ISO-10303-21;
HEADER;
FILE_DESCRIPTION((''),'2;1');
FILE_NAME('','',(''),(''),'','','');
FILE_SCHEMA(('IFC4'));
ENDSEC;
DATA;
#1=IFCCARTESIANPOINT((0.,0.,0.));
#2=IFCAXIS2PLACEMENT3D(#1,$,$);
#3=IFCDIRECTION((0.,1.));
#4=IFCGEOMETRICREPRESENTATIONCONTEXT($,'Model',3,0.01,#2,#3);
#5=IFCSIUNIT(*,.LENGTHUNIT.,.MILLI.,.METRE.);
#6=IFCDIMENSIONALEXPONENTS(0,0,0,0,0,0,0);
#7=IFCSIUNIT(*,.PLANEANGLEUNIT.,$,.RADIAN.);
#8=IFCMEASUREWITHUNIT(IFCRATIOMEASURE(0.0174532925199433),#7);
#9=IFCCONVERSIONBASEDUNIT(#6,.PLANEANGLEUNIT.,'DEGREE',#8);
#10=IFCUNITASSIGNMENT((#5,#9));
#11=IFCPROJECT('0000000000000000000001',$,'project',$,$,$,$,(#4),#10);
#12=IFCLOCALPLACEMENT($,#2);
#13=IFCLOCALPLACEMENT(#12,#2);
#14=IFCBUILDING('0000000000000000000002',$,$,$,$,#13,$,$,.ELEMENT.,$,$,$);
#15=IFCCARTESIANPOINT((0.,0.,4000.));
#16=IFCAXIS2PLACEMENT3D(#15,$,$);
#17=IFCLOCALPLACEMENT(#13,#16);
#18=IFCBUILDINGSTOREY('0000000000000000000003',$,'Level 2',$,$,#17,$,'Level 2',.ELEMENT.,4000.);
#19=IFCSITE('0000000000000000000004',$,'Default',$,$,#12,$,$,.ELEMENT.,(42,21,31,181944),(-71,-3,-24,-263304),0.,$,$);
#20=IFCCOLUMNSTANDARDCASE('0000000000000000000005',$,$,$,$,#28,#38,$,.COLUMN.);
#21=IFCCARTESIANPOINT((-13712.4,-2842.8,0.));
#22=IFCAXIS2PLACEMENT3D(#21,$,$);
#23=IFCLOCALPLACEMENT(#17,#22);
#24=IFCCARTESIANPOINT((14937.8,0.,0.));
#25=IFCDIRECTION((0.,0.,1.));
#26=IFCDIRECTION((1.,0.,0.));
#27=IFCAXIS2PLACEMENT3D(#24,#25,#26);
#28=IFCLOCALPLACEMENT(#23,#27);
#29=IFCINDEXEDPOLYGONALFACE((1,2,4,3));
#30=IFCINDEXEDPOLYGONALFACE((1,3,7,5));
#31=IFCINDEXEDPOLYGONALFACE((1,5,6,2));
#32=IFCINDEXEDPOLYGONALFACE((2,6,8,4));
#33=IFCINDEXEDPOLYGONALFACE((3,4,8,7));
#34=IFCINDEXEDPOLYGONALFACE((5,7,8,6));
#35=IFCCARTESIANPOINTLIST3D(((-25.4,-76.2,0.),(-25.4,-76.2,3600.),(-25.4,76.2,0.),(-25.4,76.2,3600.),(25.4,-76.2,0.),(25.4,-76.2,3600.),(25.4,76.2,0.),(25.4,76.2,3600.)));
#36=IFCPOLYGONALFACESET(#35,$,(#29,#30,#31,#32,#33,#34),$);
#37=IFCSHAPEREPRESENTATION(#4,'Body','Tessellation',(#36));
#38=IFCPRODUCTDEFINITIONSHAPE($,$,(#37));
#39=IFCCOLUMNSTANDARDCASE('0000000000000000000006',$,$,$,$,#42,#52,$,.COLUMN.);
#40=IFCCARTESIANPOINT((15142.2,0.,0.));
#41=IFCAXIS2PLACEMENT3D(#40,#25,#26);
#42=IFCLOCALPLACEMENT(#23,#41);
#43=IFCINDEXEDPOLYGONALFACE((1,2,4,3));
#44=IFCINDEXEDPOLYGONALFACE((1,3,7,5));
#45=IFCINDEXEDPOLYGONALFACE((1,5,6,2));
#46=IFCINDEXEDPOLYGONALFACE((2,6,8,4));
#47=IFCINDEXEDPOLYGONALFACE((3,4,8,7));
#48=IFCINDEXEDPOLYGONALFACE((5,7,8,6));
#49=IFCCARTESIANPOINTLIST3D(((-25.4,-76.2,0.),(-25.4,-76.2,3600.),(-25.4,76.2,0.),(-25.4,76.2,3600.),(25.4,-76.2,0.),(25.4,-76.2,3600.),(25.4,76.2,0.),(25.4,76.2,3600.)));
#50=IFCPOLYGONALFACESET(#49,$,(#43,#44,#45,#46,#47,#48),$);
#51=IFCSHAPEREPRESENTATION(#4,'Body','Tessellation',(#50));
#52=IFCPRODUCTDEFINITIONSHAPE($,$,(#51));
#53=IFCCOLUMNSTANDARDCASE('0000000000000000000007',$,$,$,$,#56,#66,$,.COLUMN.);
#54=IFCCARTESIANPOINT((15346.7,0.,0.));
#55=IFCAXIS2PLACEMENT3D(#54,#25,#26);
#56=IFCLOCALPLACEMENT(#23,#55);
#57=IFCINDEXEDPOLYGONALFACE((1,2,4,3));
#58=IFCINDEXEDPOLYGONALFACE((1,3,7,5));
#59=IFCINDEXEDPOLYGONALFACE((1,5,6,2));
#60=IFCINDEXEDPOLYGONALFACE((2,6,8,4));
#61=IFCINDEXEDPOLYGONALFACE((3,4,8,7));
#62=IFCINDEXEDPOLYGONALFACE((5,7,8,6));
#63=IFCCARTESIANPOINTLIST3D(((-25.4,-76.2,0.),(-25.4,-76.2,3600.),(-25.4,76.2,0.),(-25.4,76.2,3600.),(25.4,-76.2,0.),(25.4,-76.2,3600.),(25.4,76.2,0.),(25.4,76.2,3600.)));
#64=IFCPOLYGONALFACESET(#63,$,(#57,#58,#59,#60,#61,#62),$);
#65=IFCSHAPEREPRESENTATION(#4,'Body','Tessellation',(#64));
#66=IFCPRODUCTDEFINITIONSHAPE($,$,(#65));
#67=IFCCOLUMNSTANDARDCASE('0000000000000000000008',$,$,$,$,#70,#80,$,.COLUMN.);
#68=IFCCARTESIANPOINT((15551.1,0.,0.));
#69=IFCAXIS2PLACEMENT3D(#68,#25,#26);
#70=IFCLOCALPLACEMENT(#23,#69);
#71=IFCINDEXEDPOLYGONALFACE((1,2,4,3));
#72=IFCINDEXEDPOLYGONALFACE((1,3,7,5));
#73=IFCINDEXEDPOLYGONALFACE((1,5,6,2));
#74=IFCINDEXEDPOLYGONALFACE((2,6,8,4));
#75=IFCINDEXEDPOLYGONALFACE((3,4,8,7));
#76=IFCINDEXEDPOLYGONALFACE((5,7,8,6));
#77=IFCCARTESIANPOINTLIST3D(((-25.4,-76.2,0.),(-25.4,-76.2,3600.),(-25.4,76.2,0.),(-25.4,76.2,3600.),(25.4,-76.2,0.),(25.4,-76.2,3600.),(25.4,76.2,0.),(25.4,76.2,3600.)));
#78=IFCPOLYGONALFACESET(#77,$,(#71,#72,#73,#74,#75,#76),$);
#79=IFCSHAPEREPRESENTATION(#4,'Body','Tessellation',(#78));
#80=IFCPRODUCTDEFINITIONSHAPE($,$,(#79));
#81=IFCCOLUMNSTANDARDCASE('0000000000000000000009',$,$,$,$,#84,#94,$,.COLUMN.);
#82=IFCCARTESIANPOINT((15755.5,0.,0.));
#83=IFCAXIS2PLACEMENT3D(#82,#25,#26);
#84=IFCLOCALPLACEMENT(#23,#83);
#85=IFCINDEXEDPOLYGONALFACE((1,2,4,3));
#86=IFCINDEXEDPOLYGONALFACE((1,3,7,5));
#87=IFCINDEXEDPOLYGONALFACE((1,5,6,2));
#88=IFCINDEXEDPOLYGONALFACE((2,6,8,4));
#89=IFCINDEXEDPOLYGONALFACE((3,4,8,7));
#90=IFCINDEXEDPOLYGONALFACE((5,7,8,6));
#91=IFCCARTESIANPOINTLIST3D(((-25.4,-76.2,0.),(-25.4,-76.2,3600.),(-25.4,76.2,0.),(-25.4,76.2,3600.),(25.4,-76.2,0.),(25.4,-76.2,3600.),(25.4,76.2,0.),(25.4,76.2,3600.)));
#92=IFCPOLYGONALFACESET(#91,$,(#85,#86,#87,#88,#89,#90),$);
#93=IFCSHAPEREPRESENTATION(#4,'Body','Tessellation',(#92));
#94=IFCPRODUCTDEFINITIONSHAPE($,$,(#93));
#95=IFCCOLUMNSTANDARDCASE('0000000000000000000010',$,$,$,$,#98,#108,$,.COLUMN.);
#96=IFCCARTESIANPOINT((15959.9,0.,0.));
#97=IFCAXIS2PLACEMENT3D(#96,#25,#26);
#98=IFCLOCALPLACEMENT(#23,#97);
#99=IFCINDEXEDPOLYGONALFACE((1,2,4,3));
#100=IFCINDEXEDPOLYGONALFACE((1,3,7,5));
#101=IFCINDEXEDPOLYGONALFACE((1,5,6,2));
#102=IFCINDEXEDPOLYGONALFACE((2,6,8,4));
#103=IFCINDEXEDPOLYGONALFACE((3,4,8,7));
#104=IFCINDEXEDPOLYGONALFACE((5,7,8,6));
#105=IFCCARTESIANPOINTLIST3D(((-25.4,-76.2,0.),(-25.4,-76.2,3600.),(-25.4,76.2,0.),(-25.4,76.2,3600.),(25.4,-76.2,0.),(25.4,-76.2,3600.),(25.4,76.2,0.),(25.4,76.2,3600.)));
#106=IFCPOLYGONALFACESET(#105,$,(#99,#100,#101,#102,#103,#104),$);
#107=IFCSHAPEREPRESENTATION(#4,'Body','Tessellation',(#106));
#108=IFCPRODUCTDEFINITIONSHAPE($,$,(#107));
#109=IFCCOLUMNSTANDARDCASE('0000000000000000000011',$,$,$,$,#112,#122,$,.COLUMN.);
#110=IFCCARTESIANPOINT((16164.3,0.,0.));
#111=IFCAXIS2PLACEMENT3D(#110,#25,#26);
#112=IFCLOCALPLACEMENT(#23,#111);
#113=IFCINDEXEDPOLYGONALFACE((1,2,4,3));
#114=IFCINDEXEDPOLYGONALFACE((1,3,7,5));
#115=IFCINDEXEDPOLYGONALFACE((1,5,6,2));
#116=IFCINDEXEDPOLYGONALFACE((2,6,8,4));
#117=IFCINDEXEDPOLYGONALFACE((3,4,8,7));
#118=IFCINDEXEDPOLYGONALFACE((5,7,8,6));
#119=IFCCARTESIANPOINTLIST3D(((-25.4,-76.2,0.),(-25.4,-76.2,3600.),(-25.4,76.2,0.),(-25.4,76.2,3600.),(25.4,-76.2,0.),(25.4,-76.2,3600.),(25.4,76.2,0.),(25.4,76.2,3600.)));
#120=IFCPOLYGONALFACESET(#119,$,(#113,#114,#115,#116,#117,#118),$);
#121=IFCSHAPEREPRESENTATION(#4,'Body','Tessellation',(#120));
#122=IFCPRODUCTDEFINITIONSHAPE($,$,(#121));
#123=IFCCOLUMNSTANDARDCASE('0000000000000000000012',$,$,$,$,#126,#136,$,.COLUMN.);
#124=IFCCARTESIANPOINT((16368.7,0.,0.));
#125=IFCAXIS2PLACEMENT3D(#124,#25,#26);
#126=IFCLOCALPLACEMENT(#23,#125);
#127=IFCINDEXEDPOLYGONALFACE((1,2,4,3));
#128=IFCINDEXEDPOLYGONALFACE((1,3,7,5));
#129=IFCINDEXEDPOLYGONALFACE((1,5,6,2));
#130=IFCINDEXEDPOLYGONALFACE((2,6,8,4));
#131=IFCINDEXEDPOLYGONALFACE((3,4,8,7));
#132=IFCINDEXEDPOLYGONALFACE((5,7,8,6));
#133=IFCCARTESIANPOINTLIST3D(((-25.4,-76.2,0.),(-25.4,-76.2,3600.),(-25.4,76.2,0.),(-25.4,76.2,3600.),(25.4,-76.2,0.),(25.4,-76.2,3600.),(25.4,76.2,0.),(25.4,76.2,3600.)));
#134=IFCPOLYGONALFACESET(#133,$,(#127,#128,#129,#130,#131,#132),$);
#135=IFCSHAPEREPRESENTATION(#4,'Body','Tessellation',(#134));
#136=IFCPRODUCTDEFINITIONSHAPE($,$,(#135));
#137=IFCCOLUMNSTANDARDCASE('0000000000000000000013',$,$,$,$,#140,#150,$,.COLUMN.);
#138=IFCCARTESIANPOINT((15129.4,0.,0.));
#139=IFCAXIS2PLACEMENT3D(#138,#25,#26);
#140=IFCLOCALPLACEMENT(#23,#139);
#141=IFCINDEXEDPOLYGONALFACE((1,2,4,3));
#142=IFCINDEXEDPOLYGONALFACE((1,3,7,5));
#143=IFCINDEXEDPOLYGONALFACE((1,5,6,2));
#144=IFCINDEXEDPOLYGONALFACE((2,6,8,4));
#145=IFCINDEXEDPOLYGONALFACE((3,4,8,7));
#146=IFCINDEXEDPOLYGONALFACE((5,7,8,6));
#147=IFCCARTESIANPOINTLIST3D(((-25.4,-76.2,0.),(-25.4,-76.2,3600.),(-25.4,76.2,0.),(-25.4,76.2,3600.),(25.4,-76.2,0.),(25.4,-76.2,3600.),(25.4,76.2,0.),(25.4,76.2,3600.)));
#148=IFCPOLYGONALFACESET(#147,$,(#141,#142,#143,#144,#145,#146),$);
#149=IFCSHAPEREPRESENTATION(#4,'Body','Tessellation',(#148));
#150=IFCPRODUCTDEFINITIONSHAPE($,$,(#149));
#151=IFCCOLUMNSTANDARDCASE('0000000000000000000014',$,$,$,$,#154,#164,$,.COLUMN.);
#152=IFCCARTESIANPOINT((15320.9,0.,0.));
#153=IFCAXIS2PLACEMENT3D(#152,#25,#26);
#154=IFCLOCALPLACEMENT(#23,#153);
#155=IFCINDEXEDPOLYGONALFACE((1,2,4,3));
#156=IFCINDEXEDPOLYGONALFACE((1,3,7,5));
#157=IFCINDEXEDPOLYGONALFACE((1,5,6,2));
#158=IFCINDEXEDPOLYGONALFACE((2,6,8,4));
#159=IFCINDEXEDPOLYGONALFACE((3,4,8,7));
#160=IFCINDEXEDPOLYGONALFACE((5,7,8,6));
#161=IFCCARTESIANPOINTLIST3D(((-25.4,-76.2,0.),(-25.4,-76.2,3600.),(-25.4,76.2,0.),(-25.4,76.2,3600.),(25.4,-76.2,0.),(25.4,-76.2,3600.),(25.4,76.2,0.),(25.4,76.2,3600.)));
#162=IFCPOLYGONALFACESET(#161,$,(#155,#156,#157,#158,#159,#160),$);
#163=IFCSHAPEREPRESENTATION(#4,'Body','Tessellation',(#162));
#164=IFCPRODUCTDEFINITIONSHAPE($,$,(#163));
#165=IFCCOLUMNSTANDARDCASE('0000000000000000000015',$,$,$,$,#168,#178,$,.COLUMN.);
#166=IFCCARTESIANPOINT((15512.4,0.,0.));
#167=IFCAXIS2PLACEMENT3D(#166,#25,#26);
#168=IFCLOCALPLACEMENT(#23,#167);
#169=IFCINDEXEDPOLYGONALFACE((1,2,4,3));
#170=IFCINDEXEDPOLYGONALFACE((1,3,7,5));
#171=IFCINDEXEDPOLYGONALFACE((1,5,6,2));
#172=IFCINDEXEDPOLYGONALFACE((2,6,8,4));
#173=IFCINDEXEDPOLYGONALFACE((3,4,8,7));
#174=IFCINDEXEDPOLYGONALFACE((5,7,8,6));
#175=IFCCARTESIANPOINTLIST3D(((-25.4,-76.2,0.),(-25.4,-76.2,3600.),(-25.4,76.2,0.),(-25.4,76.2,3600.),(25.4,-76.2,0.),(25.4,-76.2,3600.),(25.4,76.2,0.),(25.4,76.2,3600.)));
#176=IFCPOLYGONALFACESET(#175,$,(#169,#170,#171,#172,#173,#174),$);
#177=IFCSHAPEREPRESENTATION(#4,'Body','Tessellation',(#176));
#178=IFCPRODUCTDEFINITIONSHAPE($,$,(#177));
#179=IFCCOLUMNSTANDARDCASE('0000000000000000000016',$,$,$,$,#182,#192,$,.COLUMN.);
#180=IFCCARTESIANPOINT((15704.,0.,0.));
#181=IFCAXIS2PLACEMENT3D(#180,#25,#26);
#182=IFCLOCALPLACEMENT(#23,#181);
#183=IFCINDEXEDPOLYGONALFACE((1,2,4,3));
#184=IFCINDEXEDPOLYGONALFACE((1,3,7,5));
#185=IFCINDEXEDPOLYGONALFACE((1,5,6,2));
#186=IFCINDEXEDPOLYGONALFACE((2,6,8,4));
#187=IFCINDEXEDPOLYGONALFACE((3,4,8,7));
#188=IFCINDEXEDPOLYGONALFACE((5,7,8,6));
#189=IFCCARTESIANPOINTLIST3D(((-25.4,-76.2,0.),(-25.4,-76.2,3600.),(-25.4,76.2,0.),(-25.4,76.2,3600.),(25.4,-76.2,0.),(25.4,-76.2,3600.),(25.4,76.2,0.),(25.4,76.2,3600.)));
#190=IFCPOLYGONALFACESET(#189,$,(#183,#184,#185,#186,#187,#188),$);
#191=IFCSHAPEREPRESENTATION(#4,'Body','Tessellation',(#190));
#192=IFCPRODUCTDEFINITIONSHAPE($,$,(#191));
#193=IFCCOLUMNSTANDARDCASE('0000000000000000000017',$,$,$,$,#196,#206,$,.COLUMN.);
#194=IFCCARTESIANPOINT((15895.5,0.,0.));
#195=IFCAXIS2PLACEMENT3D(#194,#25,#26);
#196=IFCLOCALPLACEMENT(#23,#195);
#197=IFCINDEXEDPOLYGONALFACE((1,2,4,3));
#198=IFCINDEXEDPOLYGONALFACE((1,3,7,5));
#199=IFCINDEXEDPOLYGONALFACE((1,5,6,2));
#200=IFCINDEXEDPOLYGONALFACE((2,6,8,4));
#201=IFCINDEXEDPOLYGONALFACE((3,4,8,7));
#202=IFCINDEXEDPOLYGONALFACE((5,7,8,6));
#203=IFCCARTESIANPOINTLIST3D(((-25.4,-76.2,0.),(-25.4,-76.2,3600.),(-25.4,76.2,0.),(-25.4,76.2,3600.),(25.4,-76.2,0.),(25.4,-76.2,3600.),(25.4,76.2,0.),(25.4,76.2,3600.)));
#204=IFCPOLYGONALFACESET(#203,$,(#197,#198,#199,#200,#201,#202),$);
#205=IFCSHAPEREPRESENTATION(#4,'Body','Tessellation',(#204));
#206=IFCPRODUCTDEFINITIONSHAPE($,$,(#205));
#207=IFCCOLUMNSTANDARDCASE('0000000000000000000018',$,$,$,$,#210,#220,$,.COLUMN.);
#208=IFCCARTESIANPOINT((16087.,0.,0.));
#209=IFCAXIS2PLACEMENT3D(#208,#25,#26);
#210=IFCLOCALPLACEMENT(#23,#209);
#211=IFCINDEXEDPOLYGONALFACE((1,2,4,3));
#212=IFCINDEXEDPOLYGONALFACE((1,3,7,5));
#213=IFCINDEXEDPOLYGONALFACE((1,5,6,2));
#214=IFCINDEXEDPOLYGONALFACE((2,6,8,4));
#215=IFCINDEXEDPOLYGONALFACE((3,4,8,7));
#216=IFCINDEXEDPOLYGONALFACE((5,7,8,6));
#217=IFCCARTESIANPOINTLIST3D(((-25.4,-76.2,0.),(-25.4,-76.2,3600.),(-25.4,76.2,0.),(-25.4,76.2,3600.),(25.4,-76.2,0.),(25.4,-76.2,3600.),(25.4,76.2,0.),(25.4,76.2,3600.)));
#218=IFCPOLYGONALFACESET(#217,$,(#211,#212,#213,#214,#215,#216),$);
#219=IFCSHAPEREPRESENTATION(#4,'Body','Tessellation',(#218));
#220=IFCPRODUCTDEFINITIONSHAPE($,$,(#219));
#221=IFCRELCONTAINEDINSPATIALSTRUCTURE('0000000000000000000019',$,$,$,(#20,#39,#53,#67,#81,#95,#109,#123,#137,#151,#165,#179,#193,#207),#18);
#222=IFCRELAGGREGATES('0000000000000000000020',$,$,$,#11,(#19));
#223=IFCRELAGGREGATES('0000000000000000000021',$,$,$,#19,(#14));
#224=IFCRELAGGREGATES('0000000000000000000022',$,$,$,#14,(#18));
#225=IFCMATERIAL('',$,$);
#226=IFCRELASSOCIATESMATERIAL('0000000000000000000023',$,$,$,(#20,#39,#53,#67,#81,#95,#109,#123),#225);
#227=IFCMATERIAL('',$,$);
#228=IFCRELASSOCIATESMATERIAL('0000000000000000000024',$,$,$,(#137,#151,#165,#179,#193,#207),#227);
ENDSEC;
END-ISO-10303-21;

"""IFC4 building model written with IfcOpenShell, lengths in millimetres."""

from ifc_helpers import new_model, entity, si_unit, converted_unit, direction, frame, origin, place, context, project, spatial, rectangle, extrude, material, element, save


model = new_model("IFC4")

# Units and contexts
model_context = context("Model", 3, precision=0.01, world=origin(), true_north=direction((0.0, 1.0)))
ifc_project = project(units=[si_unit("LENGTHUNIT", "METRE", prefix="MILLI"), converted_unit("PLANEANGLEUNIT", "DEGREE", entity("IfcRatioMeasure", 0.0174532925199433), si_unit("PLANEANGLEUNIT", "RADIAN"), dimensions=[0, 0, 0, 0, 0, 0, 0])], contexts=[model_context])

# Site, building, storey
site_placement = place(None, origin())
site = spatial("IfcSite", under=ifc_project, at=site_placement, Name="Default", CompositionType="ELEMENT", RefLatitude=(42, 21, 31, 181944), RefLongitude=(-71, -3, -24, -263304), RefElevation=0.0)
building_placement = place(site_placement, origin())
building = spatial("IfcBuilding", under=site, at=building_placement, CompositionType="ELEMENT")
storey_placement = place(building_placement, frame((0.0, 0.0, 4000.0)))
storey = spatial("IfcBuildingStorey", under=building, at=storey_placement, Name="Level 2", LongName="Level 2", CompositionType="ELEMENT", Elevation=4000.0)

# Columns
ifc_material_1 = material(Name="")
placement = place(storey_placement, frame((-13712.4, -2842.8, 0.0)))
for number, where, z_axis, x_axis in (
    (1, (14937.8, 0.0, 0.0), (0.0, 0.0, 1.0), (1.0, 0.0, 0.0)),
    (2, (15142.2, 0.0, 0.0), (0.0, 0.0, 1.0), (1.0, 0.0, 0.0)),
    (3, (15346.7, 0.0, 0.0), (0.0, 0.0, 1.0), (1.0, 0.0, 0.0)),
    (4, (15551.1, 0.0, 0.0), (0.0, 0.0, 1.0), (1.0, 0.0, 0.0)),
    (5, (15755.5, 0.0, 0.0), (0.0, 0.0, 1.0), (1.0, 0.0, 0.0)),
    (6, (15959.9, 0.0, 0.0), (0.0, 0.0, 1.0), (1.0, 0.0, 0.0)),
    (7, (16164.3, 0.0, 0.0), (0.0, 0.0, 1.0), (1.0, 0.0, 0.0)),
    (8, (16368.7, 0.0, 0.0), (0.0, 0.0, 1.0), (1.0, 0.0, 0.0)),
):
    element("IfcColumnStandardCase", number, at=place(placement, frame(where, z_axis=z_axis, x_axis=x_axis)), inside=storey, material=ifc_material_1, PredefinedType="COLUMN", context=model_context, shape_type="SweptSolid", body=[
        extrude(rectangle(XDim=50.8, YDim=152.4), origin(), (0.0, 0.0, 1.0), 3600.0),
    ])
ifc_material_2 = material(Name="")
for number, where, z_axis, x_axis in (
    (9, (15129.4, 0.0, 0.0), (0.0, 0.0, 1.0), (1.0, 0.0, 0.0)),
    (10, (15320.9, 0.0, 0.0), (0.0, 0.0, 1.0), (1.0, 0.0, 0.0)),
    (11, (15512.4, 0.0, 0.0), (0.0, 0.0, 1.0), (1.0, 0.0, 0.0)),
    (12, (15704.0, 0.0, 0.0), (0.0, 0.0, 1.0), (1.0, 0.0, 0.0)),
    (13, (15895.5, 0.0, 0.0), (0.0, 0.0, 1.0), (1.0, 0.0, 0.0)),
    (14, (16087.0, 0.0, 0.0), (0.0, 0.0, 1.0), (1.0, 0.0, 0.0)),
):
    element("IfcColumnStandardCase", number, at=place(placement, frame(where, z_axis=z_axis, x_axis=x_axis)), inside=storey, material=ifc_material_2, PredefinedType="COLUMN", context=model_context, shape_type="SweptSolid", body=[
        extrude(rectangle(XDim=50.8, YDim=152.4), origin(), (0.0, 0.0, 1.0), 3600.0),
    ])

save(model, "model.ifc")
